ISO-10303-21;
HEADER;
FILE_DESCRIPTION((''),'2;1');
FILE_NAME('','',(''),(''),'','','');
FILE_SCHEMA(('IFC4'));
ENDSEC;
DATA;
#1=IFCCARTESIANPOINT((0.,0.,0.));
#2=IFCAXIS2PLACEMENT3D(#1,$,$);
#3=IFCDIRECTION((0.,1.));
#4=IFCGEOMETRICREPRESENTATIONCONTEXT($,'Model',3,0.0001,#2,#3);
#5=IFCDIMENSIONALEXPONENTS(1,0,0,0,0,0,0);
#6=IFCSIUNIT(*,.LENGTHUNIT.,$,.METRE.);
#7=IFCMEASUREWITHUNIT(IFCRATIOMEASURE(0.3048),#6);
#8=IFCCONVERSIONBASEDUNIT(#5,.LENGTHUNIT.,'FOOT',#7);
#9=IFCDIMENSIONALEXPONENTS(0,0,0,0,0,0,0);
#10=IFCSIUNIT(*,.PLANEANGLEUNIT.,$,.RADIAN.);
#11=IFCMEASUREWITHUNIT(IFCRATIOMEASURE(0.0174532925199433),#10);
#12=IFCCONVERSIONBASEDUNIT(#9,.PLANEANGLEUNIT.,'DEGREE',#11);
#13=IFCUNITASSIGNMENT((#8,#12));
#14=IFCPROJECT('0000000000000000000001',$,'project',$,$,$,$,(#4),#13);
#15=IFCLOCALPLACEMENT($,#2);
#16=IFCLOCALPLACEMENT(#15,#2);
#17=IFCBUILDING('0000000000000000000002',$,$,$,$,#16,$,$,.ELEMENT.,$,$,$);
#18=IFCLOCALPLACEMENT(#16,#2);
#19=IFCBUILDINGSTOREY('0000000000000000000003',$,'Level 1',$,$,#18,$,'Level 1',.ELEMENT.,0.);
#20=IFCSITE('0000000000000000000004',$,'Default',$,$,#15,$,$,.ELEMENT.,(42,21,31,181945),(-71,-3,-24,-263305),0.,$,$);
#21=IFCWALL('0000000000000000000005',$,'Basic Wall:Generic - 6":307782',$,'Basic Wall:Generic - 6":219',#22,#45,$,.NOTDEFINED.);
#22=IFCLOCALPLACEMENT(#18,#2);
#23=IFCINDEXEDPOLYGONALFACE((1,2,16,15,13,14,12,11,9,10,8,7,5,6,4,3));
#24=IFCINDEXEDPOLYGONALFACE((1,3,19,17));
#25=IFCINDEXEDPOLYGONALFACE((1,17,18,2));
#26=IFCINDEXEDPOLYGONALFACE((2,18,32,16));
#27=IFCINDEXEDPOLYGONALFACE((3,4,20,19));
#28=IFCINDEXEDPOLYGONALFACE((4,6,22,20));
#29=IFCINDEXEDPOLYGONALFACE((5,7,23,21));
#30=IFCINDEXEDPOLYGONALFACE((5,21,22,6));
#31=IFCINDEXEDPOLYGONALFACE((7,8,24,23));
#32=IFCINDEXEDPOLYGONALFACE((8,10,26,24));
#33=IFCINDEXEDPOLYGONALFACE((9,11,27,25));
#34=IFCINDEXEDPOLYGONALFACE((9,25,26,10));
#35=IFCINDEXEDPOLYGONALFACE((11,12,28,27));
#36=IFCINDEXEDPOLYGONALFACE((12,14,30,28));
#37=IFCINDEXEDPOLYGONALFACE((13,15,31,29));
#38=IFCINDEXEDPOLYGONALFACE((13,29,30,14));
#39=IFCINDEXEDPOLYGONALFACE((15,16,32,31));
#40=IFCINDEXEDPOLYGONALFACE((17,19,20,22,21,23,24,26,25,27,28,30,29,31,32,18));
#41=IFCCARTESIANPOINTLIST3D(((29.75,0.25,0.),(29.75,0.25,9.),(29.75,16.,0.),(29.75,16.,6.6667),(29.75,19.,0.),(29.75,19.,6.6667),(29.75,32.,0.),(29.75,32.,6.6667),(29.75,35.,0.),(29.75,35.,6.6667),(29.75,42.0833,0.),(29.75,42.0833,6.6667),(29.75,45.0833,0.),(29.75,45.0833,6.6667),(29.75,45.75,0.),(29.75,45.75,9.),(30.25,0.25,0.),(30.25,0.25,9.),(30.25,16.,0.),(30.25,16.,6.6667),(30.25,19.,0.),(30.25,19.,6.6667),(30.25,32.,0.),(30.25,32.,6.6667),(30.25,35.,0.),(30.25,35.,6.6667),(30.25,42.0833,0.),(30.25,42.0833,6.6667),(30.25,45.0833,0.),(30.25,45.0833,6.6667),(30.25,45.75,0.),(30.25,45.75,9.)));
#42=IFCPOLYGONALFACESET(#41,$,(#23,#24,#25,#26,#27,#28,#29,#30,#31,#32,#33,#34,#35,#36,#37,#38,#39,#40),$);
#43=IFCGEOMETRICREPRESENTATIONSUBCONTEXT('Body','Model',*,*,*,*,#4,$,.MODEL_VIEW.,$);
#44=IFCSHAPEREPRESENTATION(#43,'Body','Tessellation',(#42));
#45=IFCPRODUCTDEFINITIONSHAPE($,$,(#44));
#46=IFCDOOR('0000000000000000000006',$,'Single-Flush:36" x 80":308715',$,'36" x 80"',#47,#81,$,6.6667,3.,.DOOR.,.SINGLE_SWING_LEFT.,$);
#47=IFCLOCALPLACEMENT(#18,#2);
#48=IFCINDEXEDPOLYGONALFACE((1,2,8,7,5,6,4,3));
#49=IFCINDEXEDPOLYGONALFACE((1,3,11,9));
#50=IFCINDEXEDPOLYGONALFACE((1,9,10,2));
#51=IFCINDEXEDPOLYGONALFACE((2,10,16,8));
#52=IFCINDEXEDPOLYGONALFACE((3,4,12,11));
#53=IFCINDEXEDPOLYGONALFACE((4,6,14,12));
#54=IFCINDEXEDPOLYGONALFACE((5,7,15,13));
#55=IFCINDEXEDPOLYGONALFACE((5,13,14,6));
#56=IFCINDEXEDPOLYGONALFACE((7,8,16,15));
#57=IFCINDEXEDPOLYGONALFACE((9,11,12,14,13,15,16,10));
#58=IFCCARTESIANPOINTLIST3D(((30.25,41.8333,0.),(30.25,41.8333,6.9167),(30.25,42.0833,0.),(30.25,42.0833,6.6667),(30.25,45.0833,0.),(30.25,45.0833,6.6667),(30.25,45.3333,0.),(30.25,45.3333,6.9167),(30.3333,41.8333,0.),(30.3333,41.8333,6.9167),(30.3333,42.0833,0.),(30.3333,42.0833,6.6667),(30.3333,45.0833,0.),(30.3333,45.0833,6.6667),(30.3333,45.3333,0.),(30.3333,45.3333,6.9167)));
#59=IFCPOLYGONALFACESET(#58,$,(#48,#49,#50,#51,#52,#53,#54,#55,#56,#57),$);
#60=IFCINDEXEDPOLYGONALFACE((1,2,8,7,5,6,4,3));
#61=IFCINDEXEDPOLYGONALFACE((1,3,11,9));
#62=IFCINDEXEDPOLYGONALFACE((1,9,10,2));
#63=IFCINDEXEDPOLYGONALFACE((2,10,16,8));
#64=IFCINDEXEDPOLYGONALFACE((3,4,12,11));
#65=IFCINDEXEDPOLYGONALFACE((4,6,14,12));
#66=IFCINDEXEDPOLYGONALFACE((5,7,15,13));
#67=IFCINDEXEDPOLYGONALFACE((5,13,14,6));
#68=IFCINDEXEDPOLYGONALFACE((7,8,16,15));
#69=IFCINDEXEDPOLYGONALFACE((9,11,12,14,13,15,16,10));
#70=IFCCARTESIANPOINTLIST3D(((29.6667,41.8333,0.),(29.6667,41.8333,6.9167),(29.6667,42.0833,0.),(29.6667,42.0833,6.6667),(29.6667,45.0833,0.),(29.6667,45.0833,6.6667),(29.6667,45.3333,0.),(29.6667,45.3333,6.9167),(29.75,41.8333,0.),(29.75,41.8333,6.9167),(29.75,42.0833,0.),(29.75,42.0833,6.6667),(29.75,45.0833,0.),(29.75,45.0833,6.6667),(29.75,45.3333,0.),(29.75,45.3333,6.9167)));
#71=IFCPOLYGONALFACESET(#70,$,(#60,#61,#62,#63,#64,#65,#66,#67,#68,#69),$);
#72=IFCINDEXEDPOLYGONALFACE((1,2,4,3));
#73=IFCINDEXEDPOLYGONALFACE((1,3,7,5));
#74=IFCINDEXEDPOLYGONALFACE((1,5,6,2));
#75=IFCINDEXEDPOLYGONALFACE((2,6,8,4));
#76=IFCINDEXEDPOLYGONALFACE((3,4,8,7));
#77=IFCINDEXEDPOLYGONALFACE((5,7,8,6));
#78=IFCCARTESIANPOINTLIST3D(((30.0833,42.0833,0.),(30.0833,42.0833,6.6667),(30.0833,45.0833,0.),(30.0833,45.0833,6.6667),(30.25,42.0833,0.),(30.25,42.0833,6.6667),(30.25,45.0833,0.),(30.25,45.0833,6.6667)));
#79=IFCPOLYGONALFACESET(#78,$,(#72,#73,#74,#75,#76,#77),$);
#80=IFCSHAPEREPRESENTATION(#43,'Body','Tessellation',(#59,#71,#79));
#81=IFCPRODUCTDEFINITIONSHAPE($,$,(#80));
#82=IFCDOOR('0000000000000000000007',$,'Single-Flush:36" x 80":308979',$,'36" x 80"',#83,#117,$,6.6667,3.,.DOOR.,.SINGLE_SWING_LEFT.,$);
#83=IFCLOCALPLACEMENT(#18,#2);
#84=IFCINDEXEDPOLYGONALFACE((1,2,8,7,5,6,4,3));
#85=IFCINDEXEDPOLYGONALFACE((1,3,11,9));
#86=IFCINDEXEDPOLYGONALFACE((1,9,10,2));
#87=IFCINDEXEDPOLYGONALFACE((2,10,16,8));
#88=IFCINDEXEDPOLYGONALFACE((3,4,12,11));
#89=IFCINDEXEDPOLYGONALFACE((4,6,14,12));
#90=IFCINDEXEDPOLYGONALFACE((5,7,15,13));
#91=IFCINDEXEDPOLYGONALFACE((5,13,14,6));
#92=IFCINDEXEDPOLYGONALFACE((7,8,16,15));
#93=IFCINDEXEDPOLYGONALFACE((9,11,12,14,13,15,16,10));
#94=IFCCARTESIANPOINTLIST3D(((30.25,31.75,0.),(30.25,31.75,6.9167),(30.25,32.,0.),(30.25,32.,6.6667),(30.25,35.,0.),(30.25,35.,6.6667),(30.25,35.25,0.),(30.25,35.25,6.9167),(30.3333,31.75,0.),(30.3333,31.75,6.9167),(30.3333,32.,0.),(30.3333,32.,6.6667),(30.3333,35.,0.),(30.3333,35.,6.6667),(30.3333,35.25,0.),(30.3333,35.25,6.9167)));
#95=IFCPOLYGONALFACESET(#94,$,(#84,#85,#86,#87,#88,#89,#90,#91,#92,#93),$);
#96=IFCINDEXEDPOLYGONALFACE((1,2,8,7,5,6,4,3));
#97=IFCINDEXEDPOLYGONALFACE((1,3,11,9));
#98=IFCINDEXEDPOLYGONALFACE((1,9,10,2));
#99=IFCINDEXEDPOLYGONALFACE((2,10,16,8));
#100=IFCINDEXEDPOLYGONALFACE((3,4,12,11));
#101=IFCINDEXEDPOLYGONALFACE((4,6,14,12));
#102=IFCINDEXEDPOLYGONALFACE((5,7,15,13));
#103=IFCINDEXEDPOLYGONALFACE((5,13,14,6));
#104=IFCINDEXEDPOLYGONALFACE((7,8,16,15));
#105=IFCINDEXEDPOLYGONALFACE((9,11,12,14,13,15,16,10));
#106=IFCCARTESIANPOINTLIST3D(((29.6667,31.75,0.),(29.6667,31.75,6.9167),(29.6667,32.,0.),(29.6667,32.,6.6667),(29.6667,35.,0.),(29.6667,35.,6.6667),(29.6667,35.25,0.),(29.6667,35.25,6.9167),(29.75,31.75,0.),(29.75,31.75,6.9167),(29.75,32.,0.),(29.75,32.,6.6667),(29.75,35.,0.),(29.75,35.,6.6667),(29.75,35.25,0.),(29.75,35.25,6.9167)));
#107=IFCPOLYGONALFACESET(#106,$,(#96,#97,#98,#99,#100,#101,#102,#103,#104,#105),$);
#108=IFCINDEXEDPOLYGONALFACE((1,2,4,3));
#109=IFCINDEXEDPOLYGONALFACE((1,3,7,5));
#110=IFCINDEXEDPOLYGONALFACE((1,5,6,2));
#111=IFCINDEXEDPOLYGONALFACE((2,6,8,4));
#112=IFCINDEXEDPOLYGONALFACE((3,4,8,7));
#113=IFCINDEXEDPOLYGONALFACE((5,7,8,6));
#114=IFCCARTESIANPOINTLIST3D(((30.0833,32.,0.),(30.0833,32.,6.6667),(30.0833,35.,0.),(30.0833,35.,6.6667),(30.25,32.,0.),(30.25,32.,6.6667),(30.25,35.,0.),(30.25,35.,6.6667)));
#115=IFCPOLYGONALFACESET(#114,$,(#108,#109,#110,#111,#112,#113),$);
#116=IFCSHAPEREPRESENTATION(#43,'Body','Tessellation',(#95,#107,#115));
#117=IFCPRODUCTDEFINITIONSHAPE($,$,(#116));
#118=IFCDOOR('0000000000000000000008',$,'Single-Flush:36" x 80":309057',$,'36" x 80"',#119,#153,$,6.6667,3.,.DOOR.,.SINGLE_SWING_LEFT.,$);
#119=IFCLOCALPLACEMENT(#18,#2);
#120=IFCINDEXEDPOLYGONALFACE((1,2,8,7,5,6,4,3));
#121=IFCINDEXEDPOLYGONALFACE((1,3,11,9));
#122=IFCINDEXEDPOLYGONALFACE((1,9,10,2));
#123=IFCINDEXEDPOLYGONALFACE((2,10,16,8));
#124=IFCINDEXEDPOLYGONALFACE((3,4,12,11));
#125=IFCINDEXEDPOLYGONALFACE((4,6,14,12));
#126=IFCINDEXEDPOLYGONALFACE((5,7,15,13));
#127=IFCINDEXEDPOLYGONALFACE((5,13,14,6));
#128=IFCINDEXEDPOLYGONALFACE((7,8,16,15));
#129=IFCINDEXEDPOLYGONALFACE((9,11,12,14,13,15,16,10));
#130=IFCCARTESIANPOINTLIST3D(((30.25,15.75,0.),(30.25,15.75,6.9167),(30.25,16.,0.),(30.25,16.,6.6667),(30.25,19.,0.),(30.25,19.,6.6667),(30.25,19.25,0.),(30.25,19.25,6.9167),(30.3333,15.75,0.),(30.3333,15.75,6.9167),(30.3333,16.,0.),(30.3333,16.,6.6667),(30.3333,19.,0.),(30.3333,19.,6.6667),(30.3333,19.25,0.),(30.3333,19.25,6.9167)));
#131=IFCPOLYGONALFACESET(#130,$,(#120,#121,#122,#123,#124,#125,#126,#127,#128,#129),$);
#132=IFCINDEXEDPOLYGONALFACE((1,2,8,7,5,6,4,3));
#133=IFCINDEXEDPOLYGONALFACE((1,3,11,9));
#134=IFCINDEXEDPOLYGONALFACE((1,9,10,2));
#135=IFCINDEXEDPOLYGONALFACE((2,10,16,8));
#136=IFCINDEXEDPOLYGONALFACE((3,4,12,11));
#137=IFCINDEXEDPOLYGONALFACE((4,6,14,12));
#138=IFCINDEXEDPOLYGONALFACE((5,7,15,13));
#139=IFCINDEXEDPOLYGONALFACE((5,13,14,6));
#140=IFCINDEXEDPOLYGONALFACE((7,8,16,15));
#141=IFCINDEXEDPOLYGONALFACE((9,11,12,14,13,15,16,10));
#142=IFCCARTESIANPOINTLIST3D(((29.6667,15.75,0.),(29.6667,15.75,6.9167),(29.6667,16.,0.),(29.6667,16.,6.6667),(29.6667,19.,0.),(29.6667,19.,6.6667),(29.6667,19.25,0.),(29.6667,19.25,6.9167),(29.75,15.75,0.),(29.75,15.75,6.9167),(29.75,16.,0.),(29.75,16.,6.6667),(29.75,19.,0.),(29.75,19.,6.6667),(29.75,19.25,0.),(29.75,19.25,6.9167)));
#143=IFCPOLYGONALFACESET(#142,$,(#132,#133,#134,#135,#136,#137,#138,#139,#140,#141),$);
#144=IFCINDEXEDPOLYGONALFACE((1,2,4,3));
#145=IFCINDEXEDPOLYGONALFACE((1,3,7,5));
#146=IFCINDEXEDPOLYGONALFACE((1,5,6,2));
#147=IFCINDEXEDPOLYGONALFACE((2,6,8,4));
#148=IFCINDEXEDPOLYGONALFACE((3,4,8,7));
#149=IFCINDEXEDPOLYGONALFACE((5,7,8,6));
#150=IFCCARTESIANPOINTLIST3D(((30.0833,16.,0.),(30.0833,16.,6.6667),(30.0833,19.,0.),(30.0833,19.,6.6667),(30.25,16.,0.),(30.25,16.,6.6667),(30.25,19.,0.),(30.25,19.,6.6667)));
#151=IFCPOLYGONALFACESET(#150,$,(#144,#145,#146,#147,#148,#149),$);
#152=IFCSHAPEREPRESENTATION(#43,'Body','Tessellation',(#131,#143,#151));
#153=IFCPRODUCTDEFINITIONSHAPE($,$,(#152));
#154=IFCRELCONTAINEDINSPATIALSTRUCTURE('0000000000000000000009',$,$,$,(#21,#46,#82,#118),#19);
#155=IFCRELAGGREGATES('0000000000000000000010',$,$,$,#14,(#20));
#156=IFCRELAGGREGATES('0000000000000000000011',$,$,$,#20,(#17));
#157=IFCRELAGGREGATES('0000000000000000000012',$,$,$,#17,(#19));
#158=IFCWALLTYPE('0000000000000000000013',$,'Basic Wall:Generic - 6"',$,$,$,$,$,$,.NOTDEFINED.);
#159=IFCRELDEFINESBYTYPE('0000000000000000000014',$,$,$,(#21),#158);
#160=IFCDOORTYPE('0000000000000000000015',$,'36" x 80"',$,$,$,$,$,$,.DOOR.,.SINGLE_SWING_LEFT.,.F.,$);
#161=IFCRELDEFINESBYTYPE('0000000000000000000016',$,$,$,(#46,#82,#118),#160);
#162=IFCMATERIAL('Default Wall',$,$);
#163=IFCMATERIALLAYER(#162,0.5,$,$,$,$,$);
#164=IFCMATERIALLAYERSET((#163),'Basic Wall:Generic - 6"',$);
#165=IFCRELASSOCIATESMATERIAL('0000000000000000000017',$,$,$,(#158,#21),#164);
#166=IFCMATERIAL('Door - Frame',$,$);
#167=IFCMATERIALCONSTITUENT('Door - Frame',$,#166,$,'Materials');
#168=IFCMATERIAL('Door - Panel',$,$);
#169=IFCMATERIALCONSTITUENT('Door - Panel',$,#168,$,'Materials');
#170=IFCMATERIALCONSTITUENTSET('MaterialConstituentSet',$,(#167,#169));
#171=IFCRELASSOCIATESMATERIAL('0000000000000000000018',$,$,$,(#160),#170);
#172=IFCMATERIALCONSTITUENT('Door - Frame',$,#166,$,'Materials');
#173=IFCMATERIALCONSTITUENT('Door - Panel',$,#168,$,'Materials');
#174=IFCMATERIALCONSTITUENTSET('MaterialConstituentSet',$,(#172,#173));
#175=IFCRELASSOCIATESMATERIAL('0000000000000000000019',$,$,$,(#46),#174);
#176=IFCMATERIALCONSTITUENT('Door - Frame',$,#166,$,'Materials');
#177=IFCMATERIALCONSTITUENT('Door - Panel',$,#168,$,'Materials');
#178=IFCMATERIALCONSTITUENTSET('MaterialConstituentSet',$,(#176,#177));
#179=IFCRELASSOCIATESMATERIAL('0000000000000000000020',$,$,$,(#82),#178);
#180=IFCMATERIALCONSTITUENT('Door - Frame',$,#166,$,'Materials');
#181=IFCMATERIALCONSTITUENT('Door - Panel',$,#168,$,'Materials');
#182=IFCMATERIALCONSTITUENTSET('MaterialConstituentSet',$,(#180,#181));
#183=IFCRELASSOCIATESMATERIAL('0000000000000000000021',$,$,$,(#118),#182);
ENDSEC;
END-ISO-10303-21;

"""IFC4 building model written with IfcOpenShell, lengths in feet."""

from ifc_helpers import new_model, entity, si_unit, converted_unit, direction, frame, frame_2d, origin, origin_2d_with_axis, place, context, subcontext, project, spatial, polyline, rectangle, outline, extrude, clip, bounded_halfspace, source, transform, mapped, material, layer, layer_set, layer_usage, constituent, constituent_set, type_object, type_shapes, element, fill, save


model = new_model("IFC4")

# Units and contexts
model_context = context("Model", 3, precision=0.0001, world=origin(), true_north=direction((0.0, 1.0)))
body_context = subcontext(model_context, "Body", "Model", "MODEL_VIEW")
ifc_project = project(units=[converted_unit("LENGTHUNIT", "FOOT", entity("IfcRatioMeasure", 0.3048), si_unit("LENGTHUNIT", "METRE"), dimensions=[1, 0, 0, 0, 0, 0, 0]), converted_unit("PLANEANGLEUNIT", "DEGREE", entity("IfcRatioMeasure", 0.0174532925199433), si_unit("PLANEANGLEUNIT", "RADIAN"), dimensions=[0, 0, 0, 0, 0, 0, 0])], contexts=[model_context])

# Site, building, storey
site_placement = place(None, origin())
site = spatial("IfcSite", under=ifc_project, at=site_placement, Name="Default", CompositionType="ELEMENT", RefLatitude=(42, 21, 31, 181945), RefLongitude=(-71, -3, -24, -263305), RefElevation=0.0)
building_placement = place(site_placement, origin())
building = spatial("IfcBuilding", under=site, at=building_placement, CompositionType="ELEMENT")
storey_placement = place(building_placement, origin())
storey = spatial("IfcBuildingStorey", under=building, at=storey_placement, Name="Level 1", LongName="Level 1", CompositionType="ELEMENT", Elevation=0.0)

# Shared definitions
wall_placement = place(storey_placement, frame((30.0, 45.75, 0.0), z_axis=(0.0, 0.0, 1.0), x_axis=(0.0, -1.0, 0.0)))

# Wall, openings, doors
ifc_material_1 = material(Name="Default Wall")
ifc_layer = layer(ifc_material_1, 0.5)
ifc_layer_set = layer_set([ifc_layer], Name="Basic Wall:Generic - 6\"")
ifc_layer_usage = layer_usage(ifc_layer_set, "AXIS2", "NEGATIVE", 0.25)
wall_type = type_object("IfcWallType", Name="Basic Wall:Generic - 6\"", PredefinedType="NOTDEFINED", material=ifc_layer_set)
wall = element("IfcWall", 1, at=wall_placement, inside=storey, type_object=wall_type, material=ifc_layer_usage, Name="Basic Wall:Generic - 6\":307782", ObjectType="Basic Wall:Generic - 6\":219", PredefinedType="NOTDEFINED", context=body_context, shape_type="Clipping", body=[
    clip(extrude(rectangle(XDim=45.5, YDim=0.5, at=frame_2d((22.75, 0.0), x_axis=(-1.0, 0.0))), origin(), (0.0, 0.0, 1.0), 9.0), bounded_halfspace(frame((25.5, -0.25, 9.0), z_axis=(0.0, 0.0, -1.0), x_axis=(-1.0, 0.0, 0.0)), True, frame((25.5, -0.25, 9.0)), polyline([(0.0, 0.0), (0.0, 0.5), (-15.5, 0.5), (-16.0, 0.5), (-25.5, 0.5), (-25.5, 0.0), (0.0, 0.0)]))),
])
opening_1_placement = place(wall_placement, frame((0.6667, -0.25, 0.0)))
opening_1 = element("IfcOpeningElement", 2, at=opening_1_placement, cuts=wall, ObjectType="Opening", PredefinedType="OPENING", context=body_context, shape_type="SweptSolid", body=[
    extrude(rectangle(XDim=3.0, YDim=6.6667, at=frame_2d((3.3333, 1.5), x_axis=(0.0, -1.0))), frame((0.0, 0.0, 0.0), z_axis=(0.0, 1.0, 0.0), x_axis=(0.0, 0.0, 1.0)), (0.0, 0.0, 1.0), 0.5),
])
opening_2_placement = place(wall_placement, frame((10.75, -0.25, 0.0)))
opening_2 = element("IfcOpeningElement", 3, at=opening_2_placement, cuts=wall, ObjectType="Opening", PredefinedType="OPENING", context=body_context, shape_type="SweptSolid", body=[
    extrude(rectangle(XDim=3.0, YDim=6.6667, at=frame_2d((3.3333, 1.5), x_axis=(0.0, -1.0))), frame((0.0, 0.0, 0.0), z_axis=(0.0, 1.0, 0.0), x_axis=(0.0, 0.0, 1.0)), (0.0, 0.0, 1.0), 0.5),
])
opening_3_placement = place(wall_placement, frame((26.75, -0.25, 0.0)))
opening_3 = element("IfcOpeningElement", 4, at=opening_3_placement, cuts=wall, ObjectType="Opening", PredefinedType="OPENING", context=body_context, shape_type="SweptSolid", body=[
    extrude(rectangle(XDim=3.0, YDim=6.6667, at=frame_2d((3.3333, 1.5), x_axis=(0.0, -1.0))), frame((0.0, 0.0, 0.0), z_axis=(0.0, 1.0, 0.0), x_axis=(0.0, 0.0, 1.0)), (0.0, 0.0, 1.0), 0.5),
])
ifc_material_2 = material(Name="Door - Frame")
ifc_constituent_1 = constituent(ifc_material_2, Name="Door - Frame", Category="Materials")
ifc_material_3 = material(Name="Door - Panel")
ifc_constituent_2 = constituent(ifc_material_3, Name="Door - Panel", Category="Materials")
ifc_constituent_set_1 = constituent_set(constituents=[ifc_constituent_1, ifc_constituent_2], Name="MaterialConstituentSet")
ifc_constituent_3 = constituent(ifc_material_2, Name="Door - Frame", Category="Materials")
ifc_constituent_4 = constituent(ifc_material_3, Name="Door - Panel", Category="Materials")
ifc_constituent_set_2 = constituent_set(constituents=[ifc_constituent_3, ifc_constituent_4], Name="MaterialConstituentSet")
door_type = type_object("IfcDoorType", Name="36\" x 80\"", OperationType="SINGLE_SWING_LEFT", ParameterTakesPrecedence=False, PredefinedType="DOOR", material=ifc_constituent_set_2)
shared_shape = source(origin(), body_context, "Body", "SweptSolid", [
    extrude(outline(polyline([(-1.75, -3.5208), (1.75, -3.5208), (1.75, 3.3958), (1.5, 3.3958), (1.5, -3.2708), (-1.5, -3.2708), (-1.5, 3.3958), (-1.75, 3.3958), (-1.75, -3.5208)])), frame((1.5, 0.5833, 3.3958), z_axis=(0.0, -1.0, 0.0), x_axis=(-1.0, 0.0, 0.0)), (0.0, 0.0, 1.0), 0.0833),
    extrude(outline(polyline([(-3.5208, -1.75), (3.3958, -1.75), (3.3958, -1.5), (-3.2708, -1.5), (-3.2708, 1.5), (3.3958, 1.5), (3.3958, 1.75), (-3.5208, 1.75), (-3.5208, -1.75)])), frame((1.5, 0.0, 3.3958), z_axis=(0.0, -1.0, 0.0), x_axis=(0.0, 0.0, -1.0)), (0.0, 0.0, 1.0), 0.0833),
    extrude(rectangle(XDim=3.0, YDim=0.1667, at=origin_2d_with_axis()), frame((1.5, 0.4167, 0.0)), (0.0, 0.0, 1.0), 6.6667),
])
type_shapes(door_type, [shared_shape])
door_1_placement = place(opening_1_placement, origin())
door_1 = element("IfcDoor", 5, at=door_1_placement, inside=storey, type_object=door_type, material=ifc_constituent_set_1, Name="Single-Flush:36\" x 80\":308715", ObjectType="36\" x 80\"", OperationType="SINGLE_SWING_LEFT", OverallHeight=6.6667, OverallWidth=3.0, PredefinedType="DOOR", context=body_context, shape_type="MappedRepresentation", body=[
    mapped(shared_shape, transform((0.0, 0.0, 0.0), scale=1.0)),
])
fill(opening_1, door_1)
ifc_constituent_5 = constituent(ifc_material_2, Name="Door - Frame", Category="Materials")
ifc_constituent_6 = constituent(ifc_material_3, Name="Door - Panel", Category="Materials")
ifc_constituent_set_3 = constituent_set(constituents=[ifc_constituent_5, ifc_constituent_6], Name="MaterialConstituentSet")
door_2_placement = place(opening_2_placement, origin())
door_2 = element("IfcDoor", 6, at=door_2_placement, inside=storey, type_object=door_type, material=ifc_constituent_set_3, Name="Single-Flush:36\" x 80\":308979", ObjectType="36\" x 80\"", OperationType="SINGLE_SWING_LEFT", OverallHeight=6.6667, OverallWidth=3.0, PredefinedType="DOOR", context=body_context, shape_type="MappedRepresentation", body=[
    mapped(shared_shape, transform((0.0, 0.0, 0.0), scale=1.0)),
])
fill(opening_2, door_2)
ifc_constituent_7 = constituent(ifc_material_2, Name="Door - Frame", Category="Materials")
ifc_constituent_8 = constituent(ifc_material_3, Name="Door - Panel", Category="Materials")
ifc_constituent_set_4 = constituent_set(constituents=[ifc_constituent_7, ifc_constituent_8], Name="MaterialConstituentSet")
door_3_placement = place(opening_3_placement, origin())
door_3 = element("IfcDoor", 7, at=door_3_placement, inside=storey, type_object=door_type, material=ifc_constituent_set_4, Name="Single-Flush:36\" x 80\":309057", ObjectType="36\" x 80\"", OperationType="SINGLE_SWING_LEFT", OverallHeight=6.6667, OverallWidth=3.0, PredefinedType="DOOR", context=body_context, shape_type="MappedRepresentation", body=[
    mapped(shared_shape, transform((0.0, 0.0, 0.0), scale=1.0)),
])
fill(opening_3, door_3)

save(model, "model.ifc")
